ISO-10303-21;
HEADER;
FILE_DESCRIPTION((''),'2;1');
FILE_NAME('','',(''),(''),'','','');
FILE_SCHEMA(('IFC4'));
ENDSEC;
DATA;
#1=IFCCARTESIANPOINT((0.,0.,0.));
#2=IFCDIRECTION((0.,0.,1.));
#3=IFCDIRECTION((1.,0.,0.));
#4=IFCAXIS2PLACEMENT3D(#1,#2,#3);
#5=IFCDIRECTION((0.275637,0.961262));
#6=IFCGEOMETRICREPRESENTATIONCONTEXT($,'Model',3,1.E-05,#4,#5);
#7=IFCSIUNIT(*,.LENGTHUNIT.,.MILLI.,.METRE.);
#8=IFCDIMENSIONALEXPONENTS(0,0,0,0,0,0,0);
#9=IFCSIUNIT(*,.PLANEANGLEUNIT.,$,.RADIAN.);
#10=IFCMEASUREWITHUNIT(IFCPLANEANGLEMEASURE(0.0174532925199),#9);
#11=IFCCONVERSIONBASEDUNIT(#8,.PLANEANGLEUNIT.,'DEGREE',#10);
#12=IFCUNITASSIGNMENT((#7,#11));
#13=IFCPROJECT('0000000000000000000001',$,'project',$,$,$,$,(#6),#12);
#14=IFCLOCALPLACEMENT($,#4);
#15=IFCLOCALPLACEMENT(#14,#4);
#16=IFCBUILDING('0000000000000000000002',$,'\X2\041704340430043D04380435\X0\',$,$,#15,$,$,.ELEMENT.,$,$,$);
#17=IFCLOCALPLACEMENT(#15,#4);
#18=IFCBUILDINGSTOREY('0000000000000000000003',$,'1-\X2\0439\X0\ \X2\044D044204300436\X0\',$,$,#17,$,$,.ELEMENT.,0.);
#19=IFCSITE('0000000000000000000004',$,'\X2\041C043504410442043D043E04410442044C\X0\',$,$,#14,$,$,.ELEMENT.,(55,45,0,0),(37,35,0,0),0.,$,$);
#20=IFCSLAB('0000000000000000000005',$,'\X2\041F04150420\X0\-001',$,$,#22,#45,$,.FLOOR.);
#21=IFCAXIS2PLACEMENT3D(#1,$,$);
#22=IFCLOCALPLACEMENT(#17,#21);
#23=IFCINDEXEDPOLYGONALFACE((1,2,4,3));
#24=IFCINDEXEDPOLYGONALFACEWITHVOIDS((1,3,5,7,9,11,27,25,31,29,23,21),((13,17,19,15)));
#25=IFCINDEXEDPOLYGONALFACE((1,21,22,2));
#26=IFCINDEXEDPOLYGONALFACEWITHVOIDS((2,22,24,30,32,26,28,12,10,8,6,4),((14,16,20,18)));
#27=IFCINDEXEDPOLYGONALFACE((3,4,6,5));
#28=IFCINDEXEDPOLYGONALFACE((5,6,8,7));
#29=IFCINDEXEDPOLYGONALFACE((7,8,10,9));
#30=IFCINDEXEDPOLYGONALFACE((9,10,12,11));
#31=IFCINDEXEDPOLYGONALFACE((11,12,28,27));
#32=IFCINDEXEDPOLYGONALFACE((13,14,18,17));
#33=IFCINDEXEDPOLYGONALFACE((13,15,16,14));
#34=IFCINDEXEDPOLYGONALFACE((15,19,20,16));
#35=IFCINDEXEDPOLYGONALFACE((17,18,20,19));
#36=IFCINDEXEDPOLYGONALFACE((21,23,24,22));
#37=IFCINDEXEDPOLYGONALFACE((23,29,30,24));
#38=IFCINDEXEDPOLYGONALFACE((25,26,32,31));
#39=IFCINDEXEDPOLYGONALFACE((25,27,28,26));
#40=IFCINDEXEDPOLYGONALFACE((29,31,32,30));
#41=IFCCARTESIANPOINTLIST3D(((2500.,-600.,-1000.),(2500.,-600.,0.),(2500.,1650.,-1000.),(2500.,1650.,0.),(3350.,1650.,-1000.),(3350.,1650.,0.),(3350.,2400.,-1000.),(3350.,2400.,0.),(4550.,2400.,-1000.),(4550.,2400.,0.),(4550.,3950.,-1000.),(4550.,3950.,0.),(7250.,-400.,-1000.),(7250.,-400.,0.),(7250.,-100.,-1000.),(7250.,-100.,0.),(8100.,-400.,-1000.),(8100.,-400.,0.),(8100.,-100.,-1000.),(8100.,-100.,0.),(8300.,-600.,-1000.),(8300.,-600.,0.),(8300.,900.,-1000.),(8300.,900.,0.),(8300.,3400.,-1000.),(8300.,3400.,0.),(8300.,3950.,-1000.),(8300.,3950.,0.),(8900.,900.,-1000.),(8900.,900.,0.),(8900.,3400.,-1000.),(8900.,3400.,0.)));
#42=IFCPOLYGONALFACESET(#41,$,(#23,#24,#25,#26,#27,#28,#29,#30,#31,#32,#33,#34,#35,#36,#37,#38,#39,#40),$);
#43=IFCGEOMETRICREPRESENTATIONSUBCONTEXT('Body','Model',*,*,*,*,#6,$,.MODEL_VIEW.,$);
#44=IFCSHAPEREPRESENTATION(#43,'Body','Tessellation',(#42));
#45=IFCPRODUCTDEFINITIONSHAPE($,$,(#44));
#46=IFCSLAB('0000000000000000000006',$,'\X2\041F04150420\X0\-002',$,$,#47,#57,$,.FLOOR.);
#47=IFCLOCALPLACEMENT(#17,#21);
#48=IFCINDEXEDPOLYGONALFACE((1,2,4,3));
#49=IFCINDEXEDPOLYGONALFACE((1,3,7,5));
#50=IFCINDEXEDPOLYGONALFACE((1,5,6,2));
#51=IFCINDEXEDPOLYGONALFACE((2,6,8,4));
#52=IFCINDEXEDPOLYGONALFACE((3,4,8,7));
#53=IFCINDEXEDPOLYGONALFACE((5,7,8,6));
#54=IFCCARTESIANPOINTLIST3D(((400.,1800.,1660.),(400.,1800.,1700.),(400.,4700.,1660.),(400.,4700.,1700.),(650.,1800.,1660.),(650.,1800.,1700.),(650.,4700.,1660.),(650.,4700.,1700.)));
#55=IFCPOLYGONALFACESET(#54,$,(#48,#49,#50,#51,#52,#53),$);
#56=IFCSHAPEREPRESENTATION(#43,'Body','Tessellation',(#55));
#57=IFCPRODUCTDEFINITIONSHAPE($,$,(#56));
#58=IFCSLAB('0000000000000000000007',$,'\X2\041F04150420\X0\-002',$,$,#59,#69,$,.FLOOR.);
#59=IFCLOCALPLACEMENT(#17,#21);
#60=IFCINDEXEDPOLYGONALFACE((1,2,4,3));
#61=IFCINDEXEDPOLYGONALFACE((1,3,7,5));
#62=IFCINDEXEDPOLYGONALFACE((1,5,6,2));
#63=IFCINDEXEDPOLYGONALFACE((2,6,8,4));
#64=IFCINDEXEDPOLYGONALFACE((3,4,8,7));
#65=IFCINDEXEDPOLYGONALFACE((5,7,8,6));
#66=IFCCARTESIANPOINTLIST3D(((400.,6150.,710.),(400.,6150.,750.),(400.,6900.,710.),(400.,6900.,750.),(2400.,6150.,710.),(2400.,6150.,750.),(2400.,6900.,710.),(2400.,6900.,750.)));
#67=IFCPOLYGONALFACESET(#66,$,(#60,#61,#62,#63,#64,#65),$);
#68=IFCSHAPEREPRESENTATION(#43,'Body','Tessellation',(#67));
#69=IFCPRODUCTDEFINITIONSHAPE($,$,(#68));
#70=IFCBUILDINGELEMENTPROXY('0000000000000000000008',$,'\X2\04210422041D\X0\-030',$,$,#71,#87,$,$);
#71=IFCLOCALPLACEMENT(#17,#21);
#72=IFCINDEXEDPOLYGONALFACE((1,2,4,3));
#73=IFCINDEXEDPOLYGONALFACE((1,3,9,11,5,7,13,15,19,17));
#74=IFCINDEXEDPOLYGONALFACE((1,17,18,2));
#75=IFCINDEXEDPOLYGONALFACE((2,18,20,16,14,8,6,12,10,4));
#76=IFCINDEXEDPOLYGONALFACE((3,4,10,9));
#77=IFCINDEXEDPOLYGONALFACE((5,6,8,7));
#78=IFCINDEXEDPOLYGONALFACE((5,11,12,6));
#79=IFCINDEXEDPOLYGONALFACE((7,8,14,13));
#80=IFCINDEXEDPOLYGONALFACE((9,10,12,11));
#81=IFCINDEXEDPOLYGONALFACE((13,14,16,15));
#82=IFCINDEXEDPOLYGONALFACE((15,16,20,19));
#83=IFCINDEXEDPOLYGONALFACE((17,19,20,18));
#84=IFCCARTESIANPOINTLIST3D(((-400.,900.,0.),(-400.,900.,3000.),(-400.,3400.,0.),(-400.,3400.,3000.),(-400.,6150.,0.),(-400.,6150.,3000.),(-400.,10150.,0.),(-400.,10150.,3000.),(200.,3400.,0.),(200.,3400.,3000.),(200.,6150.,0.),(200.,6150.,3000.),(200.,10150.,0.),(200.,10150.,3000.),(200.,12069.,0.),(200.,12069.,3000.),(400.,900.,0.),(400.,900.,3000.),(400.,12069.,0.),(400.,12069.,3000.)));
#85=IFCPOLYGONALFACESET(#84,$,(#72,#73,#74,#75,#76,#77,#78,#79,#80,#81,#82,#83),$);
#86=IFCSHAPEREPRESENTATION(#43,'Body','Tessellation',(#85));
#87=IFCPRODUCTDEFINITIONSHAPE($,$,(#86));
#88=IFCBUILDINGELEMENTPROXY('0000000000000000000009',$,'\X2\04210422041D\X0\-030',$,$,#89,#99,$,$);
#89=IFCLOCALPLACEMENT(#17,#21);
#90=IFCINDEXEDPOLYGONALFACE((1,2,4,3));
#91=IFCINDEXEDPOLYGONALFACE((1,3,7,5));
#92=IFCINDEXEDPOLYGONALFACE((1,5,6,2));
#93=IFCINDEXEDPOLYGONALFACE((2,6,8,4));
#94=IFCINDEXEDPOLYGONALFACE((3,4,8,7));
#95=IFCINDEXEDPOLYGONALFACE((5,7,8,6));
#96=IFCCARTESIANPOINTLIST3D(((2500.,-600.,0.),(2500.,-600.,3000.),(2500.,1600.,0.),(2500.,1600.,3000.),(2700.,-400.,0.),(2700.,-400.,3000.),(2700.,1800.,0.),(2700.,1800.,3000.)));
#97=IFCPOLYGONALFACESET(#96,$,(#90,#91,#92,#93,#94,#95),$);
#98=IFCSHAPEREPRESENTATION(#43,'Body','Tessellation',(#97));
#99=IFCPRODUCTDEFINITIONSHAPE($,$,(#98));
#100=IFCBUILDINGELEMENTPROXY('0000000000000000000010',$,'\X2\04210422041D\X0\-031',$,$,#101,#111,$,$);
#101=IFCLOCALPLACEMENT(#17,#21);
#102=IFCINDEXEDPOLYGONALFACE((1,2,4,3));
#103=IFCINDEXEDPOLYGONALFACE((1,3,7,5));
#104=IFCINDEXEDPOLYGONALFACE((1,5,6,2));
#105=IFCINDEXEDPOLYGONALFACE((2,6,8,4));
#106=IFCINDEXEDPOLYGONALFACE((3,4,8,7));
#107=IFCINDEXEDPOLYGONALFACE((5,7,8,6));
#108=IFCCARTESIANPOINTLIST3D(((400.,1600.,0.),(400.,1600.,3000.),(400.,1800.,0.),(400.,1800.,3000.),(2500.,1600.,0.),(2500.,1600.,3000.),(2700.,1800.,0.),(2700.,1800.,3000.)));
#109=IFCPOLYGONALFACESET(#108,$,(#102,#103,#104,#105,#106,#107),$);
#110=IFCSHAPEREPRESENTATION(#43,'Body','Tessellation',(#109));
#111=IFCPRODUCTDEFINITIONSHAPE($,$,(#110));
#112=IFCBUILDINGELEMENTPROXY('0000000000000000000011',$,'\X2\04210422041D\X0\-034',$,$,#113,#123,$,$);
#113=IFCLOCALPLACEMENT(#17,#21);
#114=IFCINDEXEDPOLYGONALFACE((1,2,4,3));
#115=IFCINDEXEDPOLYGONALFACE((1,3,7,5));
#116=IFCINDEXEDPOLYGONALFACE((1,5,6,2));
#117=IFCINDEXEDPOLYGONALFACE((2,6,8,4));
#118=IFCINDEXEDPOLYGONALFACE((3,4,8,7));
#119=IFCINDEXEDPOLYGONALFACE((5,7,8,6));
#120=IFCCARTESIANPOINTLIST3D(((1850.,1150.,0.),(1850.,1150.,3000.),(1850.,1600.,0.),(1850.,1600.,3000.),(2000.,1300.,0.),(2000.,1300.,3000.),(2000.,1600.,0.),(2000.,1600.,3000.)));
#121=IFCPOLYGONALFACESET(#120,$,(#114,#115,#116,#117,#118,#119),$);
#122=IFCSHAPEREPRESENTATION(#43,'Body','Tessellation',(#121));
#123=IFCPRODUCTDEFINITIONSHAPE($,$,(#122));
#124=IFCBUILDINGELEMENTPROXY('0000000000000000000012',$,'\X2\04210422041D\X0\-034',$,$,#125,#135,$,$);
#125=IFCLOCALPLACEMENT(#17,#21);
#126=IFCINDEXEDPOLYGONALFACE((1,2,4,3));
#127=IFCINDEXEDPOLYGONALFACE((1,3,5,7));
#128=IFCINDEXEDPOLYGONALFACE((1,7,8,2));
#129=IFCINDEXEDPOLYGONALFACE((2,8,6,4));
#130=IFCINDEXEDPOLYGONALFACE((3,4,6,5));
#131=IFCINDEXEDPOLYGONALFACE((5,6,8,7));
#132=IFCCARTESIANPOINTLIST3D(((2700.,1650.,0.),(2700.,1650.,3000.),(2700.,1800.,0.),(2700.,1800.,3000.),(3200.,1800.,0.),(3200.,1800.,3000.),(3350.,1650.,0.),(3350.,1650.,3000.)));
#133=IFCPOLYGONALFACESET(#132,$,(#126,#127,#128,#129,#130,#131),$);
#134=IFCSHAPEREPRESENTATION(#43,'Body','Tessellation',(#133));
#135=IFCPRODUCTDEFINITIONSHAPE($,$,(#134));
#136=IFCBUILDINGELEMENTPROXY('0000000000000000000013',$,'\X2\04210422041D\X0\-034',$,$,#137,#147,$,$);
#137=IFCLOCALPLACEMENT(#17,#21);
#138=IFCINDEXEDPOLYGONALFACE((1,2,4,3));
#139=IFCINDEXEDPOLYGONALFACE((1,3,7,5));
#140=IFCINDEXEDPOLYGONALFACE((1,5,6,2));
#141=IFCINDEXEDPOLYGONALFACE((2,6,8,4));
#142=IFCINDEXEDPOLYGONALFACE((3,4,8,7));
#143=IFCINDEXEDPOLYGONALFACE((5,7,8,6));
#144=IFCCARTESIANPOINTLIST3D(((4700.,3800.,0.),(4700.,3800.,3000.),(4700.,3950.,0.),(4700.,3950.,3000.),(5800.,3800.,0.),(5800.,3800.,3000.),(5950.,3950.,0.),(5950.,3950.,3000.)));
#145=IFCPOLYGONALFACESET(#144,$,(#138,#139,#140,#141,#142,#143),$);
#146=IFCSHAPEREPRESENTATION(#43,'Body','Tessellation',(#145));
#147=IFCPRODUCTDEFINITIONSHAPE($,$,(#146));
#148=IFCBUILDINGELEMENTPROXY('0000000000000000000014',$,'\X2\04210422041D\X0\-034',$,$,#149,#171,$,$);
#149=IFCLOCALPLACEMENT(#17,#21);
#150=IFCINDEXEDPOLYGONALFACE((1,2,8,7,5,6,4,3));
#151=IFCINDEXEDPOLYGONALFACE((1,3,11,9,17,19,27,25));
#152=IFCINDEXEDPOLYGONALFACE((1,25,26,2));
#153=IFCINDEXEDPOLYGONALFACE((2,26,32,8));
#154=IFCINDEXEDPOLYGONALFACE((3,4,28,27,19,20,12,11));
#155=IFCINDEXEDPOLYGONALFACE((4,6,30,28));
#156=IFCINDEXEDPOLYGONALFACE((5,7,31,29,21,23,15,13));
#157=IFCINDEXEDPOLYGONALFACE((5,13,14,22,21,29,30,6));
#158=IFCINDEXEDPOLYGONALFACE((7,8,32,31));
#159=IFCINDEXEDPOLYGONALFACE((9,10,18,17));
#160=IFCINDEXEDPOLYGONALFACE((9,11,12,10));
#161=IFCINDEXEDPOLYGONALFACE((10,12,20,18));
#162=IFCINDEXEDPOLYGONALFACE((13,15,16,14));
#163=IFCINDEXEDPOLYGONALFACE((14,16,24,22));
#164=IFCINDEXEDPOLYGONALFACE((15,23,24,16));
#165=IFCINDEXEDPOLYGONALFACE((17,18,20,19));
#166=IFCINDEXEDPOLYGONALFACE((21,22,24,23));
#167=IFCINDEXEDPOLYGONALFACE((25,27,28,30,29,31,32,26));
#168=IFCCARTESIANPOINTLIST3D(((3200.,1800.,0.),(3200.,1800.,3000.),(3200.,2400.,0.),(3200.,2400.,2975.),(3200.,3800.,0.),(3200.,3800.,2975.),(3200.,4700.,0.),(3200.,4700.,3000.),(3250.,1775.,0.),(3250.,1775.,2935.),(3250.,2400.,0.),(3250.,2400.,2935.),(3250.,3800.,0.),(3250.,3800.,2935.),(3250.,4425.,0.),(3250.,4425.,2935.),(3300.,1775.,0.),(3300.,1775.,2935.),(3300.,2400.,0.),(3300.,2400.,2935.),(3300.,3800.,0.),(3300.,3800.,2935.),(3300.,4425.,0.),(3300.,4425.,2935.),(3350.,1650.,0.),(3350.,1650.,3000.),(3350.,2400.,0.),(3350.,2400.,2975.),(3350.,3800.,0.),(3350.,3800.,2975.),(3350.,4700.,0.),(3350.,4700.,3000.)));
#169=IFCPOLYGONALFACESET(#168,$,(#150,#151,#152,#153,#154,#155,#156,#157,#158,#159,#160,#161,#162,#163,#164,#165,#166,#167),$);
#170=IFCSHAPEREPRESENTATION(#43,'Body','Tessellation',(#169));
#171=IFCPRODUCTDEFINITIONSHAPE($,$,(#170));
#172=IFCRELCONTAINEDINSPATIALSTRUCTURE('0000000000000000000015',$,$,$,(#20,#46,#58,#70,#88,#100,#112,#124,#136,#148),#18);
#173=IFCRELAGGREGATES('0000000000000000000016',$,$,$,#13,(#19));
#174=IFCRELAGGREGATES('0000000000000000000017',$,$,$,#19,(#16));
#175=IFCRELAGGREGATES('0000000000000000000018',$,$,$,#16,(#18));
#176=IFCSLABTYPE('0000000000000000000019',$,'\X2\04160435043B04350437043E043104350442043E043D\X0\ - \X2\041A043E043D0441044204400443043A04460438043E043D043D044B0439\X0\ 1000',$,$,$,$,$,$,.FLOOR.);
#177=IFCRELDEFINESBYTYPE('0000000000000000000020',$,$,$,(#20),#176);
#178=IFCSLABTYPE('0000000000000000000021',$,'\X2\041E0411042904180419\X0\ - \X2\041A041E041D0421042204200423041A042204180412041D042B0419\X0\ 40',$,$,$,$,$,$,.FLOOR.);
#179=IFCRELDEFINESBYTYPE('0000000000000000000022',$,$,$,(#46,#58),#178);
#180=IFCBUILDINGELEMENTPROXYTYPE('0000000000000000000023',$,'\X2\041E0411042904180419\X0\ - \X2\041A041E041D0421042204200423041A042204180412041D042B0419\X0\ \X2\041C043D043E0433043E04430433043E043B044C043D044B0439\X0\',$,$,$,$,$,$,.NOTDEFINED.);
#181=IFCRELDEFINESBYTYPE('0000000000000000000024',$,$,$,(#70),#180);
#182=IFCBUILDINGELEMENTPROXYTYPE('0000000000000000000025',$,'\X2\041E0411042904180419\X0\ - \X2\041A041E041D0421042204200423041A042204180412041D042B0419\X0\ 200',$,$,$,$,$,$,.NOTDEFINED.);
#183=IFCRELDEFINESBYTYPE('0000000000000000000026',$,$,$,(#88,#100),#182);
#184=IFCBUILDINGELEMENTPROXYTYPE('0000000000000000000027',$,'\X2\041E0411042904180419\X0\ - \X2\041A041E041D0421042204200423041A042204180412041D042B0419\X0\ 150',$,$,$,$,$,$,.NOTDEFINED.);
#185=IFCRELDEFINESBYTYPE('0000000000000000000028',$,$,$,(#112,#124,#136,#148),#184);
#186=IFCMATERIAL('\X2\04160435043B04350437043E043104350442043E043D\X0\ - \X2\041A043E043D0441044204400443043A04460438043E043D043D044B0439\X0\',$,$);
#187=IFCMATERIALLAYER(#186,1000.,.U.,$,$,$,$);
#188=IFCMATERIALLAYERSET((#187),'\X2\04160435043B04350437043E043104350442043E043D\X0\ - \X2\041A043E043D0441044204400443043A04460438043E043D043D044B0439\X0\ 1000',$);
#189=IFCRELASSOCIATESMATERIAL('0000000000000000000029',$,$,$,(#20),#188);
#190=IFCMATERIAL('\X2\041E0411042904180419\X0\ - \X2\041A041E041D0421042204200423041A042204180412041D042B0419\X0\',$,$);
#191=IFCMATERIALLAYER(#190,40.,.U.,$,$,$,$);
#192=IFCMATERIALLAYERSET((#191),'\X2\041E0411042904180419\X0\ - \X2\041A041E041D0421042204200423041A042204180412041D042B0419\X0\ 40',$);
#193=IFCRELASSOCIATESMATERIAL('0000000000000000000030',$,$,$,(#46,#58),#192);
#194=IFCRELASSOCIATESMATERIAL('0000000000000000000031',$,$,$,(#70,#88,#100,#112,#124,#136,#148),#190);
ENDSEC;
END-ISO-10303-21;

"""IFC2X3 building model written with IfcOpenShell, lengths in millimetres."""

from ifc_helpers import new_model, entity, si_unit, converted_unit, direction, frame, origin_with_axes, origin_2d_with_axis, place, context, subcontext, project, spatial, polyline, rectangle, outline, extrude, material, layer, layer_set, layer_usage, type_object, element, save


model = new_model("IFC2X3")

# Units and contexts
model_context = context("Model", 3, precision=1e-05, world=origin_with_axes(), true_north=direction((0.275637, 0.961262)))
body_context = subcontext(model_context, "Body", "Model", "MODEL_VIEW")
ifc_project = project(units=[si_unit("LENGTHUNIT", "METRE", prefix="MILLI"), converted_unit("PLANEANGLEUNIT", "DEGREE", entity("IfcPlaneAngleMeasure", 0.0174532925199), si_unit("PLANEANGLEUNIT", "RADIAN"), dimensions=[0, 0, 0, 0, 0, 0, 0])], contexts=[model_context])

# Site, building, storey
site_placement = place(None, origin_with_axes())
site = spatial("IfcSite", under=ifc_project, at=site_placement, Name="Местность", CompositionType="ELEMENT", RefLatitude=(55, 45, 0, 0), RefLongitude=(37, 35, 0, 0), RefElevation=0.0)
building_placement = place(site_placement, origin_with_axes())
building = spatial("IfcBuilding", under=site, at=building_placement, Name="Здание", CompositionType="ELEMENT")
storey_placement = place(building_placement, origin_with_axes())
storey = spatial("IfcBuildingStorey", under=building, at=storey_placement, Name="1-й этаж", CompositionType="ELEMENT", Elevation=0.0)

# Slab, opening
ifc_material_1 = material(Name="Железобетон - Конструкционный")
ifc_layer_1 = layer(ifc_material_1, 1000.0, ventilated="UNKNOWN")
ifc_layer_set_1 = layer_set([ifc_layer_1], Name="Железобетон - Конструкционный 1000")
ifc_layer_usage_1 = layer_usage(ifc_layer_set_1, "AXIS3", "NEGATIVE", 1000.0)
slab_type_1 = type_object("IfcSlabType", Name="Железобетон - Конструкционный 1000", PredefinedType="FLOOR")
slab_1_placement = place(storey_placement, frame((2500.0, -600.0, 0.0), z_axis=(0.0, 0.0, 1.0), x_axis=(1.0, 0.0, 0.0)))
slab_1 = element("IfcSlab", 1, at=slab_1_placement, inside=storey, type_object=slab_type_1, material=ifc_layer_usage_1, Name="ПЕР-001", PredefinedType="FLOOR", context=body_context, shape_type="SweptSolid", body=[
    extrude(outline(polyline([(0.0, 0.0), (5800.0, 0.0), (5800.0, 1500.0), (6400.0, 1500.0), (6400.0, 4000.0), (5800.0, 4000.0), (5800.0, 4550.0), (2050.0, 4550.0), (2050.0, 3000.0), (850.0, 3000.0), (850.0, 2250.0), (0.0, 2250.0), (0.0, 0.0)])), frame((0.0, 0.0, -1000.0), z_axis=(0.0, 0.0, 1.0), x_axis=(1.0, 0.0, 0.0)), (0.0, 0.0, 1.0), 1000.0),
])
opening_1_placement = place(slab_1_placement, origin_with_axes())
element("IfcOpeningElement", 2, at=opening_1_placement, cuts=slab_1, context=body_context, shape_type="SweptSolid", body=[
    extrude(outline(polyline([(4750.0, 500.0), (4750.0, 200.0), (5600.0, 200.0), (5600.0, 500.0), (4750.0, 500.0)])), frame((0.0, 0.0, -1000.0), z_axis=(0.0, 0.0, 1.0), x_axis=(1.0, 0.0, 0.0)), (0.0, 0.0, 1.0), 1000.0),
])

# Slabs
ifc_material_2 = material(Name="ОБЩИЙ - КОНСТРУКТИВНЫЙ")
ifc_layer_2 = layer(ifc_material_2, 40.0, ventilated="UNKNOWN")
ifc_layer_set_2 = layer_set([ifc_layer_2], Name="ОБЩИЙ - КОНСТРУКТИВНЫЙ 40")
ifc_layer_usage_2 = layer_usage(ifc_layer_set_2, "AXIS3", "NEGATIVE", 40.0)
slab_type_2 = type_object("IfcSlabType", Name="ОБЩИЙ - КОНСТРУКТИВНЫЙ 40", PredefinedType="FLOOR")
slab_2_placement = place(storey_placement, frame((400.0, 1800.0, 1700.0), z_axis=(0.0, 0.0, 1.0), x_axis=(1.0, 0.0, 0.0)))
element("IfcSlab", 3, at=slab_2_placement, inside=storey, type_object=slab_type_2, material=ifc_layer_usage_2, Name="ПЕР-002", PredefinedType="FLOOR", context=body_context, shape_type="SweptSolid", body=[
    extrude(outline(polyline([(0.0, 0.0), (250.0, 0.0), (250.0, 2900.0), (0.0, 2900.0), (0.0, 0.0)])), frame((0.0, 0.0, -40.0), z_axis=(0.0, 0.0, 1.0), x_axis=(1.0, 0.0, 0.0)), (0.0, 0.0, 1.0), 40.0),
])
ifc_layer_usage_3 = layer_usage(ifc_layer_set_2, "AXIS3", "NEGATIVE", 40.0)
slab_3_placement = place(storey_placement, frame((2400.0, 6900.0, 750.0), z_axis=(0.0, 0.0, 1.0), x_axis=(1.0, 0.0, 0.0)))
element("IfcSlab", 4, at=slab_3_placement, inside=storey, type_object=slab_type_2, material=ifc_layer_usage_3, Name="ПЕР-002", PredefinedType="FLOOR", context=body_context, shape_type="SweptSolid", body=[
    extrude(outline(polyline([(0.0, 0.0), (-2000.0, 0.0), (-2000.0, -750.0), (0.0, -750.0), (0.0, 0.0)])), frame((0.0, 0.0, -40.0), z_axis=(0.0, 0.0, 1.0), x_axis=(1.0, 0.0, 0.0)), (0.0, 0.0, 1.0), 40.0),
])

# Building element proxies
building_element_proxy_type_1 = type_object("IfcBuildingElementProxyType", Name="ОБЩИЙ - КОНСТРУКТИВНЫЙ Многоугольный", PredefinedType="NOTDEFINED")
proxy_1_placement = place(storey_placement, frame((400.0, 900.0, 0.0), z_axis=(0.0, 0.0, 1.0), x_axis=(0.0, 1.0, 0.0)))
element("IfcBuildingElementProxy", 5, at=proxy_1_placement, inside=storey, type_object=building_element_proxy_type_1, material=ifc_material_2, Name="СТН-030", context=body_context, shape_type="SweptSolid", body=[
    extrude(outline(polyline([(0.0, 0.0), (11169.0, 0.0), (11169.0, 200.0), (9250.0, 200.0), (9250.0, 800.0), (5250.0, 800.0), (5250.0, 200.0), (2500.0, 200.0), (2500.0, 800.0), (0.0, 800.0), (0.0, 0.0)])), origin_with_axes(), (0.0, 0.0, 1.0), 3000.0),
])
building_element_proxy_type_2 = type_object("IfcBuildingElementProxyType", Name="ОБЩИЙ - КОНСТРУКТИВНЫЙ 200", PredefinedType="NOTDEFINED")
proxy_2_placement = place(storey_placement, frame((2700.0, -600.0, 0.0), z_axis=(0.0, 0.0, 1.0), x_axis=(0.0, 1.0, 0.0)))
element("IfcBuildingElementProxy", 6, at=proxy_2_placement, inside=storey, type_object=building_element_proxy_type_2, material=ifc_material_2, Name="СТН-030", context=body_context, shape_type="SweptSolid", body=[
    extrude(outline(polyline([(200.0, 0.0), (2400.0, 0.0), (2200.0, 200.0), (0.0, 200.0), (200.0, 0.0)])), origin_with_axes(), (0.0, 0.0, 1.0), 3000.0),
])
proxy_3_placement = place(storey_placement, frame((2700.0, 1600.0, 0.0), z_axis=(0.0, 0.0, 1.0), x_axis=(-1.0, 0.0, 0.0)))
element("IfcBuildingElementProxy", 7, at=proxy_3_placement, inside=storey, type_object=building_element_proxy_type_2, material=ifc_material_2, Name="СТН-031", context=body_context, shape_type="SweptSolid", body=[
    extrude(outline(polyline([(0.0, -200.0), (2300.0, -200.0), (2300.0, 0.0), (200.0, 0.0), (0.0, -200.0)])), origin_with_axes(), (0.0, 0.0, 1.0), 3000.0),
])
building_element_proxy_type_3 = type_object("IfcBuildingElementProxyType", Name="ОБЩИЙ - КОНСТРУКТИВНЫЙ 150", PredefinedType="NOTDEFINED")
proxy_4_placement = place(storey_placement, frame((2000.0, 1300.0, 0.0), z_axis=(0.0, 0.0, 1.0), x_axis=(0.0, 1.0, 0.0)))
element("IfcBuildingElementProxy", 8, at=proxy_4_placement, inside=storey, type_object=building_element_proxy_type_3, material=ifc_material_2, Name="СТН-034", context=body_context, shape_type="SweptSolid", body=[
    extrude(outline(polyline([(0.0, 0.0), (300.0, 0.0), (300.0, 150.0), (-150.0, 150.0), (0.0, 0.0)])), origin_with_axes(), (0.0, 0.0, 1.0), 3000.0),
])
proxy_5_placement = place(storey_placement, frame((2700.0, 1800.0, 0.0), z_axis=(0.0, 0.0, 1.0), x_axis=(1.0, 0.0, 0.0)))
element("IfcBuildingElementProxy", 9, at=proxy_5_placement, inside=storey, type_object=building_element_proxy_type_3, material=ifc_material_2, Name="СТН-034", context=body_context, shape_type="SweptSolid", body=[
    extrude(outline(polyline([(0.0, -150.0), (650.0, -150.0), (500.0, 0.0), (0.0, 0.0), (0.0, -150.0)])), origin_with_axes(), (0.0, 0.0, 1.0), 3000.0),
])
proxy_6_placement = place(storey_placement, frame((4550.0, 3800.0, 0.0), z_axis=(0.0, 0.0, 1.0), x_axis=(1.0, 0.0, 0.0)))
element("IfcBuildingElementProxy", 10, at=proxy_6_placement, inside=storey, type_object=building_element_proxy_type_3, material=ifc_material_2, Name="СТН-034", context=body_context, shape_type="SweptSolid", body=[
    extrude(outline(polyline([(150.0, 0.0), (1250.0, 0.0), (1400.0, 150.0), (150.0, 150.0), (150.0, 0.0)])), origin_with_axes(), (0.0, 0.0, 1.0), 3000.0),
])

# Building element proxy, opening
proxy_7_placement = place(storey_placement, frame((3200.0, 1800.0, 0.0), z_axis=(0.0, 0.0, 1.0), x_axis=(0.0, 1.0, 0.0)))
proxy_7 = element("IfcBuildingElementProxy", 11, at=proxy_7_placement, inside=storey, type_object=building_element_proxy_type_3, material=ifc_material_2, Name="СТН-034", context=body_context, shape_type="SweptSolid", body=[
    extrude(outline(polyline([(-150.0, -150.0), (2900.0, -150.0), (2900.0, 0.0), (0.0, 0.0), (-150.0, -150.0)])), origin_with_axes(), (0.0, 0.0, 1.0), 3000.0),
])
opening_2_placement = place(proxy_7_placement, frame((1300.0, 0.0, 0.0), z_axis=(0.0, 0.0, 1.0), x_axis=(1.0, 0.0, 0.0)))
element("IfcOpeningElement", 12, at=opening_2_placement, cuts=proxy_7, context=body_context, shape_type="SweptSolid", body=[
    extrude(rectangle(XDim=1400.0, YDim=2975.0, at=origin_2d_with_axis()), frame((0.0, 150.0, 1487.5), z_axis=(0.0, -1.0, 0.0), x_axis=(1.0, 0.0, 0.0)), (0.0, 0.0, 1.0), 450.0),
    extrude(outline(polyline([(1325.0, 0.0), (1325.0, 2935.0), (700.0, 2935.0), (700.0, 0.0), (1325.0, 0.0)])), frame((0.0, -50.0, 0.0), z_axis=(0.0, -1.0, 0.0), x_axis=(1.0, 0.0, 0.0)), (0.0, 0.0, 1.0), 50.0),
    extrude(outline(polyline([(-1325.0, 0.0), (-700.0, 0.0), (-700.0, 2935.0), (-1325.0, 2935.0), (-1325.0, 0.0)])), frame((0.0, -50.0, 0.0), z_axis=(0.0, -1.0, 0.0), x_axis=(1.0, 0.0, 0.0)), (0.0, 0.0, 1.0), 50.0),
    extrude(rectangle(XDim=1444.0, YDim=2997.0, at=origin_2d_with_axis()), frame((0.0, 0.0, 1498.5), z_axis=(0.0, -1.0, 0.0), x_axis=(1.0, 0.0, 0.0)), (0.0, 0.0, -1.0), 150.0),
    extrude(rectangle(XDim=1444.0, YDim=2997.0, at=origin_2d_with_axis()), frame((0.0, -150.0, 1498.5), z_axis=(0.0, 1.0, 0.0), x_axis=(1.0, 0.0, 0.0)), (0.0, 0.0, -1.0), 150.0),
])

save(model, "model.ifc")
